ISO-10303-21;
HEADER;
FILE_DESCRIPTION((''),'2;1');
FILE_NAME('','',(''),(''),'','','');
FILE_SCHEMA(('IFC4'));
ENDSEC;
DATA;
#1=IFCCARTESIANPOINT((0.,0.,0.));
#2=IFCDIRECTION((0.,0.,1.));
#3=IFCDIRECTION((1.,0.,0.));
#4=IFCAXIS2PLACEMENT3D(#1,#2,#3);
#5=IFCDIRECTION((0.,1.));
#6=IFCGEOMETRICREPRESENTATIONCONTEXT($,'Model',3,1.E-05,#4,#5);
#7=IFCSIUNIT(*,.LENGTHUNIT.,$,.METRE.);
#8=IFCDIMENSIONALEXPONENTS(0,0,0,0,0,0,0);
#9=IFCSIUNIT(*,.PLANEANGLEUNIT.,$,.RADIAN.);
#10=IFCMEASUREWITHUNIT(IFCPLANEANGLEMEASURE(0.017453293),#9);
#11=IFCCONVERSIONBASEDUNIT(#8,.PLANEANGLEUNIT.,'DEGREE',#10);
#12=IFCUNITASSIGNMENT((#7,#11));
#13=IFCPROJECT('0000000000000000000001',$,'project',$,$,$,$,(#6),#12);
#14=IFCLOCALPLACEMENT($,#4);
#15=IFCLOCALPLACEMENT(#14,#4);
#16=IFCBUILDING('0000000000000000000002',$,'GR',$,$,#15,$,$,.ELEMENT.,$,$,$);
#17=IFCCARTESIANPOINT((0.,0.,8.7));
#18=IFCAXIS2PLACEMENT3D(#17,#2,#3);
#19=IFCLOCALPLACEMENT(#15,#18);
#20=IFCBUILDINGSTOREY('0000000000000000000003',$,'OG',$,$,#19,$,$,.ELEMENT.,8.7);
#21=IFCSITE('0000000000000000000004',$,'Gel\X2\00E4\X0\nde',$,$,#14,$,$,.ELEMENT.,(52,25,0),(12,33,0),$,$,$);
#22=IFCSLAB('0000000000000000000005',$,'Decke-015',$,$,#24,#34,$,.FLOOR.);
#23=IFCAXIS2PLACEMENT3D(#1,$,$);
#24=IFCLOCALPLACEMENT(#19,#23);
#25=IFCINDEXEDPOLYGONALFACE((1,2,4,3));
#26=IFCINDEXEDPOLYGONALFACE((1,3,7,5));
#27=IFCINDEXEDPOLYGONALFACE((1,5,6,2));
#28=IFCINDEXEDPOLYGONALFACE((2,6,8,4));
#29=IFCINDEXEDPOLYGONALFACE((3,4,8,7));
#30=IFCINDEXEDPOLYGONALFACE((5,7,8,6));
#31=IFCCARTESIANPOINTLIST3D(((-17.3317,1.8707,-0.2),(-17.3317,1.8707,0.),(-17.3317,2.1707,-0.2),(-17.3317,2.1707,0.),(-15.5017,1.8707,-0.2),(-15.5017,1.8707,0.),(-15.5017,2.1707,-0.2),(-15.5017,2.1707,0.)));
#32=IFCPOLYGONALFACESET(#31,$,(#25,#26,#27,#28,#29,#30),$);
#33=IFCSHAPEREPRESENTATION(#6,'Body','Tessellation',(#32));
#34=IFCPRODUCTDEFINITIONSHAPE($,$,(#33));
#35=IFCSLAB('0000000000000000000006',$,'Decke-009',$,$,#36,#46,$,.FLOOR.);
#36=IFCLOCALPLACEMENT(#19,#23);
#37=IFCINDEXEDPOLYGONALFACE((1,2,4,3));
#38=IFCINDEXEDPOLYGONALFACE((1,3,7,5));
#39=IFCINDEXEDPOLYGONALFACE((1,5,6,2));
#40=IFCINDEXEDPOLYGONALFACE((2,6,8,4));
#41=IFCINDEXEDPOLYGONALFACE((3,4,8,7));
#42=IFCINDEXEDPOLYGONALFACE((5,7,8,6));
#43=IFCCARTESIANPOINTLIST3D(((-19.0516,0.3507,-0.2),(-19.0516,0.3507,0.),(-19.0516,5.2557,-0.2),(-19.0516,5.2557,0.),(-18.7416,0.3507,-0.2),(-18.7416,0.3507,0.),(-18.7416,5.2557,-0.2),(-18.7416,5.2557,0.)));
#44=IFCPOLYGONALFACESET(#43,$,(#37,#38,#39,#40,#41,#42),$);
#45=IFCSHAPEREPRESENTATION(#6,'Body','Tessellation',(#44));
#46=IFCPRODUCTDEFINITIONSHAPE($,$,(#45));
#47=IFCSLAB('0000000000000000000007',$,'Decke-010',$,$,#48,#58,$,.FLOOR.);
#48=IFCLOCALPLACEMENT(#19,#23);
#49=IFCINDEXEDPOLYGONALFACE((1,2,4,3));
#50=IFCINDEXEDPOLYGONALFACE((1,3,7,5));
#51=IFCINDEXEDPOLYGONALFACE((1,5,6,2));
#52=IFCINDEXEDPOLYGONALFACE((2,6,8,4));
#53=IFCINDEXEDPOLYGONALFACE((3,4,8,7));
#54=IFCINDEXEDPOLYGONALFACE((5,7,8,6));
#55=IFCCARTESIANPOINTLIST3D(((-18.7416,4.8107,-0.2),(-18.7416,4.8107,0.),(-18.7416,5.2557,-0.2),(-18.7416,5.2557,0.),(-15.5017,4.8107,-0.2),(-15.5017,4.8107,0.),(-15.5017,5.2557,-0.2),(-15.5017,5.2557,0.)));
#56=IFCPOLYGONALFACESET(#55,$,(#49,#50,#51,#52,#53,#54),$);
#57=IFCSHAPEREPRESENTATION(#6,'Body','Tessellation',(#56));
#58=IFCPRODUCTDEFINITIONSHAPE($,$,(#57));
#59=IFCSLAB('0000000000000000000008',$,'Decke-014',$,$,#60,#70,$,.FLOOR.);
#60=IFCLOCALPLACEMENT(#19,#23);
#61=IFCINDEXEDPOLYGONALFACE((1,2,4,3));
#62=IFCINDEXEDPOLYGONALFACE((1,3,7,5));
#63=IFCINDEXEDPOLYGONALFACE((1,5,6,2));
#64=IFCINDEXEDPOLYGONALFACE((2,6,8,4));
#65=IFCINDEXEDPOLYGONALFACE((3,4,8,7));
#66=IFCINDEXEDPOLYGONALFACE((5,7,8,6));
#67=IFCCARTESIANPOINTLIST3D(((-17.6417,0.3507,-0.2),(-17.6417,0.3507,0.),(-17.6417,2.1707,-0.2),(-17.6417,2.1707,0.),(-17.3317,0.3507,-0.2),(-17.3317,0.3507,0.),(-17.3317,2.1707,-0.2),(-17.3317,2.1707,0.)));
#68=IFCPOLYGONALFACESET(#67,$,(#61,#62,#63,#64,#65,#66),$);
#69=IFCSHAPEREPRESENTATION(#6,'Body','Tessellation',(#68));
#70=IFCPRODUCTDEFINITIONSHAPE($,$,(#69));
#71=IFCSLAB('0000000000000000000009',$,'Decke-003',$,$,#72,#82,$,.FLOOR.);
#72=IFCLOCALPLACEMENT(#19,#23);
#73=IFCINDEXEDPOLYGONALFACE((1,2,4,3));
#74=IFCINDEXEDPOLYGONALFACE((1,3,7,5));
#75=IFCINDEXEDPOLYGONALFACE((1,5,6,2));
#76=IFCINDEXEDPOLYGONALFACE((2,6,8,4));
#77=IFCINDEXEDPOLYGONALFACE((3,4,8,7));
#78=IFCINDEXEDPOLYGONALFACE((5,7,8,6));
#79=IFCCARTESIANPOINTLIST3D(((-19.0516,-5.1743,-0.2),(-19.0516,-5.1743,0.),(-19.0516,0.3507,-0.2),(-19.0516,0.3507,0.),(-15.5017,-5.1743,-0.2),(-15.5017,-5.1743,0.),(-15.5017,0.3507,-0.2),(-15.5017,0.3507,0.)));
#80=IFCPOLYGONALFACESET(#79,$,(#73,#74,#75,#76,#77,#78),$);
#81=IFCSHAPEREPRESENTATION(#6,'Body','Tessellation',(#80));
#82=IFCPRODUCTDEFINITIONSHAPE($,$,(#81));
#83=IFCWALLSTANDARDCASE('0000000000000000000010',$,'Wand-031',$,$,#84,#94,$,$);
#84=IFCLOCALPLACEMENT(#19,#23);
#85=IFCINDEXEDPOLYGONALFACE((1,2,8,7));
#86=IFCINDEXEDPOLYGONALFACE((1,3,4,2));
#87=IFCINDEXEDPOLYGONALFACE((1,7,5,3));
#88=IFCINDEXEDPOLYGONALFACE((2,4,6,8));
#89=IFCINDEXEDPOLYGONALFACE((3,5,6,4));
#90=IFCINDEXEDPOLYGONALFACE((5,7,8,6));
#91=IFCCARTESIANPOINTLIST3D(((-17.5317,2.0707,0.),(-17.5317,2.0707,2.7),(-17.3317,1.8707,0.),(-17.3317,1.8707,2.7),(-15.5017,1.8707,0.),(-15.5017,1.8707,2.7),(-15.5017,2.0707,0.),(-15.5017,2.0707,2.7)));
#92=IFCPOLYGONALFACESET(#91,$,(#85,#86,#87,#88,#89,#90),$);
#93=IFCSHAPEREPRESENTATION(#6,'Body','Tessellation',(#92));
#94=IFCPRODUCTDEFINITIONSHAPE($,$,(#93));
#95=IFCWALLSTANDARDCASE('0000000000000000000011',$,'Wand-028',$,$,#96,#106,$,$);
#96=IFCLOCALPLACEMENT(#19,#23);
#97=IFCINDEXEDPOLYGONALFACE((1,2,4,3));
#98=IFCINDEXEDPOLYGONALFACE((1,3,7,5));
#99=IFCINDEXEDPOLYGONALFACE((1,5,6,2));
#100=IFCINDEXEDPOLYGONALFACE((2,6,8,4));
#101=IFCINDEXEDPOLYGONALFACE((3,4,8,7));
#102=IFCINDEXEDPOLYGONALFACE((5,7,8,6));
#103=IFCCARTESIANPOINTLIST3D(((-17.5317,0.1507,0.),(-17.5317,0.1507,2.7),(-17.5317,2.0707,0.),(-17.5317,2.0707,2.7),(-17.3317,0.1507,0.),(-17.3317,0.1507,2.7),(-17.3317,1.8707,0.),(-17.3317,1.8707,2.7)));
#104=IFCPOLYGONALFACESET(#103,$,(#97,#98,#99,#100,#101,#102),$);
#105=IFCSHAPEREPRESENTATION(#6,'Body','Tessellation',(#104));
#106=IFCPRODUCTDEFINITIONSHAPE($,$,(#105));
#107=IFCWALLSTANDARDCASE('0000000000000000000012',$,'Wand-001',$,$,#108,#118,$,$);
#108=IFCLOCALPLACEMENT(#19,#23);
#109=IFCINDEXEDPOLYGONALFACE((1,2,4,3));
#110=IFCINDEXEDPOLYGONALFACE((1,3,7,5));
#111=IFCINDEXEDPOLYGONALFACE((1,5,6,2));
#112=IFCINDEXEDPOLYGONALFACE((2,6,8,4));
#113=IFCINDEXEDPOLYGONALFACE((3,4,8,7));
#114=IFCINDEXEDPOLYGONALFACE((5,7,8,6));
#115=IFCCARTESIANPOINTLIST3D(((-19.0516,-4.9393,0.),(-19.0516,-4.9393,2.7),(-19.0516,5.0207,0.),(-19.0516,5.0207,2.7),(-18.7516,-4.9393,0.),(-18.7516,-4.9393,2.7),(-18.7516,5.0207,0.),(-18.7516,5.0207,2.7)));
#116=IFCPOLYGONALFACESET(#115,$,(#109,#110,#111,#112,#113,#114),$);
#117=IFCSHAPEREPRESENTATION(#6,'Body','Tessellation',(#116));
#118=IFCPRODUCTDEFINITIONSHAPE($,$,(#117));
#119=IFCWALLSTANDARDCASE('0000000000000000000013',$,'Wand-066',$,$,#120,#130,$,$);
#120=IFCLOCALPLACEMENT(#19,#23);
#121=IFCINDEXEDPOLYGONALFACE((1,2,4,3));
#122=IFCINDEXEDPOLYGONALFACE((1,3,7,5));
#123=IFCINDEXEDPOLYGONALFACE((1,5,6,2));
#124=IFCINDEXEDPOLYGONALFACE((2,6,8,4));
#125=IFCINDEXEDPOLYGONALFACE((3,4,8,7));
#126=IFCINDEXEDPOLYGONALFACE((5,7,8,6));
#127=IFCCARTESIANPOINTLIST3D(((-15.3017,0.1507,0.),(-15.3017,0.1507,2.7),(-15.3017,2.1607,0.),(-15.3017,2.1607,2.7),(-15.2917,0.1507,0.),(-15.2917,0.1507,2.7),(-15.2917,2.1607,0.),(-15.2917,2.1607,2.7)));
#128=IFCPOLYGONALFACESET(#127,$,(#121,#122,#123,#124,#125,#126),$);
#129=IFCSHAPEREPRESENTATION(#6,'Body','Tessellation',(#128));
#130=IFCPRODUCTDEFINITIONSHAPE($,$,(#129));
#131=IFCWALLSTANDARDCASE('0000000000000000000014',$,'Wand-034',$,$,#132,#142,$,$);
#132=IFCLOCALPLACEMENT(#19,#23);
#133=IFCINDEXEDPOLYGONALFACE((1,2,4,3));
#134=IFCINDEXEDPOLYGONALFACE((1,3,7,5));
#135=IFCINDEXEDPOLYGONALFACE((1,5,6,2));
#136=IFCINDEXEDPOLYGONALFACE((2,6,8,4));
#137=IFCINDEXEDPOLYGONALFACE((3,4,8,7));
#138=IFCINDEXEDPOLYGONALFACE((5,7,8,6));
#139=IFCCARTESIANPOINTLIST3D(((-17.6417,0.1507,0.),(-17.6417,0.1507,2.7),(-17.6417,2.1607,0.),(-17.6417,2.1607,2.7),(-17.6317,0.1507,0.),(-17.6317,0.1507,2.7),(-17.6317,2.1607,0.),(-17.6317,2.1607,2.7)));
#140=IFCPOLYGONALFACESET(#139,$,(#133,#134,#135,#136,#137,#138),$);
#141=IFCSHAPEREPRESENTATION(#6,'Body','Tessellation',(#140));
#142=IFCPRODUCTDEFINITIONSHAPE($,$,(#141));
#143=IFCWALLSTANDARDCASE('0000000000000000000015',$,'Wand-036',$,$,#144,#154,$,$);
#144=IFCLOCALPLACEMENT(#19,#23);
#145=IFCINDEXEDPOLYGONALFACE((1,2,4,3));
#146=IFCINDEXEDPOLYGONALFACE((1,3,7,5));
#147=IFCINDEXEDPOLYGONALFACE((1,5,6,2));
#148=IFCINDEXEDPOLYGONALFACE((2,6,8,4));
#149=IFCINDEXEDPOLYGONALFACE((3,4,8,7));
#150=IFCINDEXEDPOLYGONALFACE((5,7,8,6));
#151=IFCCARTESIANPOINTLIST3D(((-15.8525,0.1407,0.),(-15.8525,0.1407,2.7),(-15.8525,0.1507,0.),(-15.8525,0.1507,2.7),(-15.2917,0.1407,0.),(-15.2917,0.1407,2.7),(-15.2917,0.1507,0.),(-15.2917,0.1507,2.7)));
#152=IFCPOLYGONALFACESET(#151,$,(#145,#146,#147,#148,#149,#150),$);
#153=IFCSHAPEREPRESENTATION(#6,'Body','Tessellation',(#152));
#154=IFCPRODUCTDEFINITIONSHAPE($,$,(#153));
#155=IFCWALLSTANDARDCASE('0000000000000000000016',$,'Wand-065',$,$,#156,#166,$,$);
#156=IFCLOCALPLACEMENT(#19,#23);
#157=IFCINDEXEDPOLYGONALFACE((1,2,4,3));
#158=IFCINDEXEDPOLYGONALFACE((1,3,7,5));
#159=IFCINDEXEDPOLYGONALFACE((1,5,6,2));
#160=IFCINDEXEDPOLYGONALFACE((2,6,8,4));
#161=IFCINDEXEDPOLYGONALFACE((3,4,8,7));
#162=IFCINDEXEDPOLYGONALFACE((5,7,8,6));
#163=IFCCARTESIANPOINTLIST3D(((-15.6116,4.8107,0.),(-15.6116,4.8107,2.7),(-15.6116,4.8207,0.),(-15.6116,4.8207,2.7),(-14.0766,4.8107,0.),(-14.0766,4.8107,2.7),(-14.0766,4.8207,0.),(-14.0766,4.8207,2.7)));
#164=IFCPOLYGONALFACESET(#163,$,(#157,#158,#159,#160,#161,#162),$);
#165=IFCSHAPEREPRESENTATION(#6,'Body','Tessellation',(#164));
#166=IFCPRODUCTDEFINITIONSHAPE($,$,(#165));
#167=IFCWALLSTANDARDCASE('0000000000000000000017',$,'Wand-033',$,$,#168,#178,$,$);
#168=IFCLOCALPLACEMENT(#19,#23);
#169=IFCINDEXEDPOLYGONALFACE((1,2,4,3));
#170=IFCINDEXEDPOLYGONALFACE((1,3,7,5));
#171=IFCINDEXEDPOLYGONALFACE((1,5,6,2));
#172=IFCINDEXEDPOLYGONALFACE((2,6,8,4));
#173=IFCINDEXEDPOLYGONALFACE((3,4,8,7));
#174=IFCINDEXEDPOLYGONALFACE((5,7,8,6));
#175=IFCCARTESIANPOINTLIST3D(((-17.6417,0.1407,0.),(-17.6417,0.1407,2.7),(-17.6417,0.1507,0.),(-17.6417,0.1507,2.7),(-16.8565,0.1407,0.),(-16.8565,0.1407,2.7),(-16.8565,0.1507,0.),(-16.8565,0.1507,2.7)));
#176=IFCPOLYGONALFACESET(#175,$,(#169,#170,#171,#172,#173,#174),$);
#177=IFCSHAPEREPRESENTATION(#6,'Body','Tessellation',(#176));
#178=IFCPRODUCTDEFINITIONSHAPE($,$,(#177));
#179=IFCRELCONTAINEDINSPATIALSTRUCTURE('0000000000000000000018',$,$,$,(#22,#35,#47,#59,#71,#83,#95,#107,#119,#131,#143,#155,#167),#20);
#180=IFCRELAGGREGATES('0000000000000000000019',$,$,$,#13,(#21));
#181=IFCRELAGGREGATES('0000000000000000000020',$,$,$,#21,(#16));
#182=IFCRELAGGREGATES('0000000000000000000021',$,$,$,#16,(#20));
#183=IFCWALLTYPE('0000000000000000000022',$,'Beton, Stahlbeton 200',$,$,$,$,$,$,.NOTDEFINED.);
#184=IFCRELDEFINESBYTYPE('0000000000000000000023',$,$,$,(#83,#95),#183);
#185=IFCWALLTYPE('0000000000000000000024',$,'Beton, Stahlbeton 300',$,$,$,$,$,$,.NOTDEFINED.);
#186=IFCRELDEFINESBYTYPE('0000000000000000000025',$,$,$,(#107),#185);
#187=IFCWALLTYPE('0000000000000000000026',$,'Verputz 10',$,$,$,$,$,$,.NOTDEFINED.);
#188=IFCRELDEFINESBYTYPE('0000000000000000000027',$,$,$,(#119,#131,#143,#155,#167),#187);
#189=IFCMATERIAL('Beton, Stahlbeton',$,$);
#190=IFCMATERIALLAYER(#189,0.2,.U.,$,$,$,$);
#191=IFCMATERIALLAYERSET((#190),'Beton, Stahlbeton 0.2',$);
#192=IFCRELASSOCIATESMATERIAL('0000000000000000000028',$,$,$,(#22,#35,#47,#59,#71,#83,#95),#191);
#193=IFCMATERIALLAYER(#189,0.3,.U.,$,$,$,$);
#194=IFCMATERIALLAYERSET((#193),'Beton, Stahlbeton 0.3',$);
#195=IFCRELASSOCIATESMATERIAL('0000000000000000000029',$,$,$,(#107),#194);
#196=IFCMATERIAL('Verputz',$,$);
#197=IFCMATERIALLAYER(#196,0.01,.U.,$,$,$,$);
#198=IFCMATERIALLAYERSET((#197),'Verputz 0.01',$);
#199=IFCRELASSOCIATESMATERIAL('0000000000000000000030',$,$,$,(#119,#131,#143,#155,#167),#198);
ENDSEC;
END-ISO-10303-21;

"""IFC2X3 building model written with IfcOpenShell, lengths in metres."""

from ifc_helpers import new_model, entity, si_unit, converted_unit, direction, frame, origin_with_axes, place, context, project, spatial, polyline, outline, extrude, material, layer, layer_set, layer_usage, type_object, element, save


model = new_model("IFC2X3")

# Units and contexts
model_context = context("Model", 3, precision=1e-05, world=origin_with_axes(), true_north=direction((0.0, 1.0)))
ifc_project = project(units=[si_unit("LENGTHUNIT", "METRE"), converted_unit("PLANEANGLEUNIT", "DEGREE", entity("IfcPlaneAngleMeasure", 0.017453293), si_unit("PLANEANGLEUNIT", "RADIAN"), dimensions=[0, 0, 0, 0, 0, 0, 0])], contexts=[model_context])

# Site, building, storey
site_placement = place(None, origin_with_axes())
site = spatial("IfcSite", under=ifc_project, at=site_placement, Name="Gelände", CompositionType="ELEMENT", RefLatitude=(52, 25, 0), RefLongitude=(12, 33, 0))
building_placement = place(site_placement, origin_with_axes())
building = spatial("IfcBuilding", under=site, at=building_placement, Name="GR", CompositionType="ELEMENT")
storey_placement = place(building_placement, frame((0.0, 0.0, 8.7), z_axis=(0.0, 0.0, 1.0), x_axis=(1.0, 0.0, 0.0)))
storey = spatial("IfcBuildingStorey", under=building, at=storey_placement, Name="OG", CompositionType="ELEMENT", Elevation=8.7)

# Slabs
ifc_material_1 = material(Name="Beton, Stahlbeton")
ifc_layer_1 = layer(ifc_material_1, 0.2, ventilated="UNKNOWN")
ifc_layer_set_1 = layer_set([ifc_layer_1], Name="Beton, Stahlbeton 0.2")
ifc_layer_usage_1 = layer_usage(ifc_layer_set_1, "AXIS3", "NEGATIVE", 0.2)
slab_1_placement = place(storey_placement, frame((-17.3317, 1.8707, -0.2), z_axis=(0.0, 0.0, 1.0), x_axis=(1.0, 0.0, 0.0)))
element("IfcSlab", 1, at=slab_1_placement, inside=storey, material=ifc_layer_usage_1, Name="Decke-015", PredefinedType="FLOOR", context=model_context, shape_type="SweptSolid", body=[
    extrude(outline(polyline([(0.0, 0.0), (1.83, 0.0), (1.83, 0.3), (0.0, 0.3), (0.0, 0.0)])), origin_with_axes(), (0.0, 0.0, 1.0), 0.2),
])
ifc_layer_usage_2 = layer_usage(ifc_layer_set_1, "AXIS3", "NEGATIVE", 0.2)
slab_2_placement = place(storey_placement, frame((-18.7416, 0.3507, -0.2), z_axis=(0.0, 0.0, 1.0), x_axis=(1.0, 0.0, 0.0)))
element("IfcSlab", 2, at=slab_2_placement, inside=storey, material=ifc_layer_usage_2, Name="Decke-009", PredefinedType="FLOOR", context=model_context, shape_type="SweptSolid", body=[
    extrude(outline(polyline([(0.0, 0.0), (0.0, 4.905), (-0.31, 4.905), (-0.31, 0.0), (0.0, 0.0)])), origin_with_axes(), (0.0, 0.0, 1.0), 0.2),
])
ifc_layer_usage_3 = layer_usage(ifc_layer_set_1, "AXIS3", "NEGATIVE", 0.2)
slab_3_placement = place(storey_placement, frame((-18.7416, 5.2557, -0.2), z_axis=(0.0, 0.0, 1.0), x_axis=(1.0, 0.0, 0.0)))
element("IfcSlab", 3, at=slab_3_placement, inside=storey, material=ifc_layer_usage_3, Name="Decke-010", PredefinedType="FLOOR", context=model_context, shape_type="SweptSolid", body=[
    extrude(outline(polyline([(0.0, 0.0), (0.0, -0.445), (3.24, -0.445), (3.24, 0.0), (0.0, 0.0)])), origin_with_axes(), (0.0, 0.0, 1.0), 0.2),
])
ifc_layer_usage_4 = layer_usage(ifc_layer_set_1, "AXIS3", "NEGATIVE", 0.2)
slab_4_placement = place(storey_placement, frame((-17.6417, 0.3507, -0.2), z_axis=(0.0, 0.0, 1.0), x_axis=(1.0, 0.0, 0.0)))
element("IfcSlab", 4, at=slab_4_placement, inside=storey, material=ifc_layer_usage_4, Name="Decke-014", PredefinedType="FLOOR", context=model_context, shape_type="SweptSolid", body=[
    extrude(outline(polyline([(0.0, 0.0), (0.31, 0.0), (0.31, 1.82), (0.0, 1.82), (0.0, 0.0)])), origin_with_axes(), (0.0, 0.0, 1.0), 0.2),
])
ifc_layer_usage_5 = layer_usage(ifc_layer_set_1, "AXIS3", "NEGATIVE", 0.2)
slab_5_placement = place(storey_placement, frame((-15.5017, 0.3507, -0.2), z_axis=(0.0, 0.0, 1.0), x_axis=(1.0, 0.0, 0.0)))
element("IfcSlab", 5, at=slab_5_placement, inside=storey, material=ifc_layer_usage_5, Name="Decke-003", PredefinedType="FLOOR", context=model_context, shape_type="SweptSolid", body=[
    extrude(outline(polyline([(0.0, 0.0), (-3.55, 0.0), (-3.55, -5.525), (0.0, -5.525), (0.0, 0.0)])), origin_with_axes(), (0.0, 0.0, 1.0), 0.2),
])

# Shared definitions
wall_type_1 = type_object("IfcWallType", Name="Beton, Stahlbeton 200", PredefinedType="NOTDEFINED")

# Walls
ifc_layer_usage_6 = layer_usage(ifc_layer_set_1, "AXIS2", "NEGATIVE", 0.0)
wall_1_placement = place(storey_placement, frame((-17.5317, 2.0707, 0.0), z_axis=(0.0, 0.0, 1.0), x_axis=(1.0, 0.0, 0.0)))
element("IfcWallStandardCase", 6, at=wall_1_placement, inside=storey, type_object=wall_type_1, material=ifc_layer_usage_6, Name="Wand-031", context=model_context, shape_type="SweptSolid", body=[
    extrude(outline(polyline([(0.2, -0.2), (2.03, -0.2), (2.03, 0.0), (0.0, 0.0), (0.2, -0.2)])), origin_with_axes(), (0.0, 0.0, 1.0), 2.7),
])
ifc_layer_usage_7 = layer_usage(ifc_layer_set_1, "AXIS2", "NEGATIVE", 0.0)
wall_2_placement = place(storey_placement, frame((-17.5317, 0.1507, 0.0), z_axis=(0.0, 0.0, 1.0), x_axis=(0.0, 1.0, 0.0)))
element("IfcWallStandardCase", 7, at=wall_2_placement, inside=storey, type_object=wall_type_1, material=ifc_layer_usage_7, Name="Wand-028", context=model_context, shape_type="SweptSolid", body=[
    extrude(outline(polyline([(0.0, -0.2), (1.72, -0.2), (1.92, 0.0), (0.0, 0.0), (0.0, -0.2)])), origin_with_axes(), (0.0, 0.0, 1.0), 2.7),
])
ifc_layer_2 = layer(ifc_material_1, 0.3, ventilated="UNKNOWN")
ifc_layer_set_2 = layer_set([ifc_layer_2], Name="Beton, Stahlbeton 0.3")
ifc_layer_usage_8 = layer_usage(ifc_layer_set_2, "AXIS2", "POSITIVE", 0.0)
wall_type_2 = type_object("IfcWallType", Name="Beton, Stahlbeton 300", PredefinedType="NOTDEFINED")
wall_3_placement = place(storey_placement, frame((-19.0516, 5.0207, 0.0), z_axis=(0.0, 0.0, 1.0), x_axis=(0.0, -1.0, 0.0)))
element("IfcWallStandardCase", 8, at=wall_3_placement, inside=storey, type_object=wall_type_2, material=ifc_layer_usage_8, Name="Wand-001", context=model_context, shape_type="SweptSolid", body=[
    extrude(outline(polyline([(0.0, 0.0), (9.96, 0.0), (9.96, 0.3), (0.0, 0.3), (0.0, 0.0)])), origin_with_axes(), (0.0, 0.0, 1.0), 2.7),
])
ifc_material_2 = material(Name="Verputz")
ifc_layer_3 = layer(ifc_material_2, 0.01, ventilated="UNKNOWN")
ifc_layer_set_3 = layer_set([ifc_layer_3], Name="Verputz 0.01")
ifc_layer_usage_9 = layer_usage(ifc_layer_set_3, "AXIS2", "POSITIVE", 0.0)
wall_type_3 = type_object("IfcWallType", Name="Verputz 10", PredefinedType="NOTDEFINED")
wall_4_placement = place(storey_placement, frame((-15.3017, 2.1607, 0.0), z_axis=(0.0, 0.0, 1.0), x_axis=(0.0, -1.0, 0.0)))
element("IfcWallStandardCase", 9, at=wall_4_placement, inside=storey, type_object=wall_type_3, material=ifc_layer_usage_9, Name="Wand-066", context=model_context, shape_type="SweptSolid", body=[
    extrude(outline(polyline([(0.0, 0.0), (2.01, 0.0), (2.01, 0.01), (0.0, 0.01), (0.0, 0.0)])), origin_with_axes(), (0.0, 0.0, 1.0), 2.7),
])
ifc_layer_usage_10 = layer_usage(ifc_layer_set_3, "AXIS2", "POSITIVE", 0.0)
wall_5_placement = place(storey_placement, frame((-17.6317, 0.1507, 0.0), z_axis=(0.0, 0.0, 1.0), x_axis=(0.0, 1.0, 0.0)))
element("IfcWallStandardCase", 10, at=wall_5_placement, inside=storey, type_object=wall_type_3, material=ifc_layer_usage_10, Name="Wand-034", context=model_context, shape_type="SweptSolid", body=[
    extrude(outline(polyline([(0.0, 0.0), (2.01, 0.0), (2.01, 0.01), (0.0, 0.01), (0.0, 0.0)])), origin_with_axes(), (0.0, 0.0, 1.0), 2.7),
])
ifc_layer_usage_11 = layer_usage(ifc_layer_set_3, "AXIS2", "NEGATIVE", 0.0)
wall_6_placement = place(storey_placement, frame((-15.8525, 0.1507, 0.0), z_axis=(0.0, 0.0, 1.0), x_axis=(1.0, 0.0, 0.0)))
element("IfcWallStandardCase", 11, at=wall_6_placement, inside=storey, type_object=wall_type_3, material=ifc_layer_usage_11, Name="Wand-036", context=model_context, shape_type="SweptSolid", body=[
    extrude(outline(polyline([(0.0, -0.01), (0.5609, -0.01), (0.5609, 0.0), (0.0, 0.0), (0.0, -0.01)])), origin_with_axes(), (0.0, 0.0, 1.0), 2.7),
])
ifc_layer_usage_12 = layer_usage(ifc_layer_set_3, "AXIS2", "NEGATIVE", 0.0)
wall_7_placement = place(storey_placement, frame((-15.6116, 4.8207, 0.0), z_axis=(0.0, 0.0, 1.0), x_axis=(1.0, 0.0, 0.0)))
element("IfcWallStandardCase", 12, at=wall_7_placement, inside=storey, type_object=wall_type_3, material=ifc_layer_usage_12, Name="Wand-065", context=model_context, shape_type="SweptSolid", body=[
    extrude(outline(polyline([(0.0, -0.01), (1.535, -0.01), (1.535, 0.0), (0.0, 0.0), (0.0, -0.01)])), origin_with_axes(), (0.0, 0.0, 1.0), 2.7),
])
ifc_layer_usage_13 = layer_usage(ifc_layer_set_3, "AXIS2", "POSITIVE", 0.0)
wall_8_placement = place(storey_placement, frame((-16.8565, 0.1507, 0.0), z_axis=(0.0, 0.0, 1.0), x_axis=(-1.0, 0.0, 0.0)))
element("IfcWallStandardCase", 13, at=wall_8_placement, inside=storey, type_object=wall_type_3, material=ifc_layer_usage_13, Name="Wand-033", context=model_context, shape_type="SweptSolid", body=[
    extrude(outline(polyline([(0.0, 0.0), (0.7852, 0.0), (0.7852, 0.01), (0.0, 0.01), (0.0, 0.0)])), origin_with_axes(), (0.0, 0.0, 1.0), 2.7),
])

save(model, "model.ifc")
